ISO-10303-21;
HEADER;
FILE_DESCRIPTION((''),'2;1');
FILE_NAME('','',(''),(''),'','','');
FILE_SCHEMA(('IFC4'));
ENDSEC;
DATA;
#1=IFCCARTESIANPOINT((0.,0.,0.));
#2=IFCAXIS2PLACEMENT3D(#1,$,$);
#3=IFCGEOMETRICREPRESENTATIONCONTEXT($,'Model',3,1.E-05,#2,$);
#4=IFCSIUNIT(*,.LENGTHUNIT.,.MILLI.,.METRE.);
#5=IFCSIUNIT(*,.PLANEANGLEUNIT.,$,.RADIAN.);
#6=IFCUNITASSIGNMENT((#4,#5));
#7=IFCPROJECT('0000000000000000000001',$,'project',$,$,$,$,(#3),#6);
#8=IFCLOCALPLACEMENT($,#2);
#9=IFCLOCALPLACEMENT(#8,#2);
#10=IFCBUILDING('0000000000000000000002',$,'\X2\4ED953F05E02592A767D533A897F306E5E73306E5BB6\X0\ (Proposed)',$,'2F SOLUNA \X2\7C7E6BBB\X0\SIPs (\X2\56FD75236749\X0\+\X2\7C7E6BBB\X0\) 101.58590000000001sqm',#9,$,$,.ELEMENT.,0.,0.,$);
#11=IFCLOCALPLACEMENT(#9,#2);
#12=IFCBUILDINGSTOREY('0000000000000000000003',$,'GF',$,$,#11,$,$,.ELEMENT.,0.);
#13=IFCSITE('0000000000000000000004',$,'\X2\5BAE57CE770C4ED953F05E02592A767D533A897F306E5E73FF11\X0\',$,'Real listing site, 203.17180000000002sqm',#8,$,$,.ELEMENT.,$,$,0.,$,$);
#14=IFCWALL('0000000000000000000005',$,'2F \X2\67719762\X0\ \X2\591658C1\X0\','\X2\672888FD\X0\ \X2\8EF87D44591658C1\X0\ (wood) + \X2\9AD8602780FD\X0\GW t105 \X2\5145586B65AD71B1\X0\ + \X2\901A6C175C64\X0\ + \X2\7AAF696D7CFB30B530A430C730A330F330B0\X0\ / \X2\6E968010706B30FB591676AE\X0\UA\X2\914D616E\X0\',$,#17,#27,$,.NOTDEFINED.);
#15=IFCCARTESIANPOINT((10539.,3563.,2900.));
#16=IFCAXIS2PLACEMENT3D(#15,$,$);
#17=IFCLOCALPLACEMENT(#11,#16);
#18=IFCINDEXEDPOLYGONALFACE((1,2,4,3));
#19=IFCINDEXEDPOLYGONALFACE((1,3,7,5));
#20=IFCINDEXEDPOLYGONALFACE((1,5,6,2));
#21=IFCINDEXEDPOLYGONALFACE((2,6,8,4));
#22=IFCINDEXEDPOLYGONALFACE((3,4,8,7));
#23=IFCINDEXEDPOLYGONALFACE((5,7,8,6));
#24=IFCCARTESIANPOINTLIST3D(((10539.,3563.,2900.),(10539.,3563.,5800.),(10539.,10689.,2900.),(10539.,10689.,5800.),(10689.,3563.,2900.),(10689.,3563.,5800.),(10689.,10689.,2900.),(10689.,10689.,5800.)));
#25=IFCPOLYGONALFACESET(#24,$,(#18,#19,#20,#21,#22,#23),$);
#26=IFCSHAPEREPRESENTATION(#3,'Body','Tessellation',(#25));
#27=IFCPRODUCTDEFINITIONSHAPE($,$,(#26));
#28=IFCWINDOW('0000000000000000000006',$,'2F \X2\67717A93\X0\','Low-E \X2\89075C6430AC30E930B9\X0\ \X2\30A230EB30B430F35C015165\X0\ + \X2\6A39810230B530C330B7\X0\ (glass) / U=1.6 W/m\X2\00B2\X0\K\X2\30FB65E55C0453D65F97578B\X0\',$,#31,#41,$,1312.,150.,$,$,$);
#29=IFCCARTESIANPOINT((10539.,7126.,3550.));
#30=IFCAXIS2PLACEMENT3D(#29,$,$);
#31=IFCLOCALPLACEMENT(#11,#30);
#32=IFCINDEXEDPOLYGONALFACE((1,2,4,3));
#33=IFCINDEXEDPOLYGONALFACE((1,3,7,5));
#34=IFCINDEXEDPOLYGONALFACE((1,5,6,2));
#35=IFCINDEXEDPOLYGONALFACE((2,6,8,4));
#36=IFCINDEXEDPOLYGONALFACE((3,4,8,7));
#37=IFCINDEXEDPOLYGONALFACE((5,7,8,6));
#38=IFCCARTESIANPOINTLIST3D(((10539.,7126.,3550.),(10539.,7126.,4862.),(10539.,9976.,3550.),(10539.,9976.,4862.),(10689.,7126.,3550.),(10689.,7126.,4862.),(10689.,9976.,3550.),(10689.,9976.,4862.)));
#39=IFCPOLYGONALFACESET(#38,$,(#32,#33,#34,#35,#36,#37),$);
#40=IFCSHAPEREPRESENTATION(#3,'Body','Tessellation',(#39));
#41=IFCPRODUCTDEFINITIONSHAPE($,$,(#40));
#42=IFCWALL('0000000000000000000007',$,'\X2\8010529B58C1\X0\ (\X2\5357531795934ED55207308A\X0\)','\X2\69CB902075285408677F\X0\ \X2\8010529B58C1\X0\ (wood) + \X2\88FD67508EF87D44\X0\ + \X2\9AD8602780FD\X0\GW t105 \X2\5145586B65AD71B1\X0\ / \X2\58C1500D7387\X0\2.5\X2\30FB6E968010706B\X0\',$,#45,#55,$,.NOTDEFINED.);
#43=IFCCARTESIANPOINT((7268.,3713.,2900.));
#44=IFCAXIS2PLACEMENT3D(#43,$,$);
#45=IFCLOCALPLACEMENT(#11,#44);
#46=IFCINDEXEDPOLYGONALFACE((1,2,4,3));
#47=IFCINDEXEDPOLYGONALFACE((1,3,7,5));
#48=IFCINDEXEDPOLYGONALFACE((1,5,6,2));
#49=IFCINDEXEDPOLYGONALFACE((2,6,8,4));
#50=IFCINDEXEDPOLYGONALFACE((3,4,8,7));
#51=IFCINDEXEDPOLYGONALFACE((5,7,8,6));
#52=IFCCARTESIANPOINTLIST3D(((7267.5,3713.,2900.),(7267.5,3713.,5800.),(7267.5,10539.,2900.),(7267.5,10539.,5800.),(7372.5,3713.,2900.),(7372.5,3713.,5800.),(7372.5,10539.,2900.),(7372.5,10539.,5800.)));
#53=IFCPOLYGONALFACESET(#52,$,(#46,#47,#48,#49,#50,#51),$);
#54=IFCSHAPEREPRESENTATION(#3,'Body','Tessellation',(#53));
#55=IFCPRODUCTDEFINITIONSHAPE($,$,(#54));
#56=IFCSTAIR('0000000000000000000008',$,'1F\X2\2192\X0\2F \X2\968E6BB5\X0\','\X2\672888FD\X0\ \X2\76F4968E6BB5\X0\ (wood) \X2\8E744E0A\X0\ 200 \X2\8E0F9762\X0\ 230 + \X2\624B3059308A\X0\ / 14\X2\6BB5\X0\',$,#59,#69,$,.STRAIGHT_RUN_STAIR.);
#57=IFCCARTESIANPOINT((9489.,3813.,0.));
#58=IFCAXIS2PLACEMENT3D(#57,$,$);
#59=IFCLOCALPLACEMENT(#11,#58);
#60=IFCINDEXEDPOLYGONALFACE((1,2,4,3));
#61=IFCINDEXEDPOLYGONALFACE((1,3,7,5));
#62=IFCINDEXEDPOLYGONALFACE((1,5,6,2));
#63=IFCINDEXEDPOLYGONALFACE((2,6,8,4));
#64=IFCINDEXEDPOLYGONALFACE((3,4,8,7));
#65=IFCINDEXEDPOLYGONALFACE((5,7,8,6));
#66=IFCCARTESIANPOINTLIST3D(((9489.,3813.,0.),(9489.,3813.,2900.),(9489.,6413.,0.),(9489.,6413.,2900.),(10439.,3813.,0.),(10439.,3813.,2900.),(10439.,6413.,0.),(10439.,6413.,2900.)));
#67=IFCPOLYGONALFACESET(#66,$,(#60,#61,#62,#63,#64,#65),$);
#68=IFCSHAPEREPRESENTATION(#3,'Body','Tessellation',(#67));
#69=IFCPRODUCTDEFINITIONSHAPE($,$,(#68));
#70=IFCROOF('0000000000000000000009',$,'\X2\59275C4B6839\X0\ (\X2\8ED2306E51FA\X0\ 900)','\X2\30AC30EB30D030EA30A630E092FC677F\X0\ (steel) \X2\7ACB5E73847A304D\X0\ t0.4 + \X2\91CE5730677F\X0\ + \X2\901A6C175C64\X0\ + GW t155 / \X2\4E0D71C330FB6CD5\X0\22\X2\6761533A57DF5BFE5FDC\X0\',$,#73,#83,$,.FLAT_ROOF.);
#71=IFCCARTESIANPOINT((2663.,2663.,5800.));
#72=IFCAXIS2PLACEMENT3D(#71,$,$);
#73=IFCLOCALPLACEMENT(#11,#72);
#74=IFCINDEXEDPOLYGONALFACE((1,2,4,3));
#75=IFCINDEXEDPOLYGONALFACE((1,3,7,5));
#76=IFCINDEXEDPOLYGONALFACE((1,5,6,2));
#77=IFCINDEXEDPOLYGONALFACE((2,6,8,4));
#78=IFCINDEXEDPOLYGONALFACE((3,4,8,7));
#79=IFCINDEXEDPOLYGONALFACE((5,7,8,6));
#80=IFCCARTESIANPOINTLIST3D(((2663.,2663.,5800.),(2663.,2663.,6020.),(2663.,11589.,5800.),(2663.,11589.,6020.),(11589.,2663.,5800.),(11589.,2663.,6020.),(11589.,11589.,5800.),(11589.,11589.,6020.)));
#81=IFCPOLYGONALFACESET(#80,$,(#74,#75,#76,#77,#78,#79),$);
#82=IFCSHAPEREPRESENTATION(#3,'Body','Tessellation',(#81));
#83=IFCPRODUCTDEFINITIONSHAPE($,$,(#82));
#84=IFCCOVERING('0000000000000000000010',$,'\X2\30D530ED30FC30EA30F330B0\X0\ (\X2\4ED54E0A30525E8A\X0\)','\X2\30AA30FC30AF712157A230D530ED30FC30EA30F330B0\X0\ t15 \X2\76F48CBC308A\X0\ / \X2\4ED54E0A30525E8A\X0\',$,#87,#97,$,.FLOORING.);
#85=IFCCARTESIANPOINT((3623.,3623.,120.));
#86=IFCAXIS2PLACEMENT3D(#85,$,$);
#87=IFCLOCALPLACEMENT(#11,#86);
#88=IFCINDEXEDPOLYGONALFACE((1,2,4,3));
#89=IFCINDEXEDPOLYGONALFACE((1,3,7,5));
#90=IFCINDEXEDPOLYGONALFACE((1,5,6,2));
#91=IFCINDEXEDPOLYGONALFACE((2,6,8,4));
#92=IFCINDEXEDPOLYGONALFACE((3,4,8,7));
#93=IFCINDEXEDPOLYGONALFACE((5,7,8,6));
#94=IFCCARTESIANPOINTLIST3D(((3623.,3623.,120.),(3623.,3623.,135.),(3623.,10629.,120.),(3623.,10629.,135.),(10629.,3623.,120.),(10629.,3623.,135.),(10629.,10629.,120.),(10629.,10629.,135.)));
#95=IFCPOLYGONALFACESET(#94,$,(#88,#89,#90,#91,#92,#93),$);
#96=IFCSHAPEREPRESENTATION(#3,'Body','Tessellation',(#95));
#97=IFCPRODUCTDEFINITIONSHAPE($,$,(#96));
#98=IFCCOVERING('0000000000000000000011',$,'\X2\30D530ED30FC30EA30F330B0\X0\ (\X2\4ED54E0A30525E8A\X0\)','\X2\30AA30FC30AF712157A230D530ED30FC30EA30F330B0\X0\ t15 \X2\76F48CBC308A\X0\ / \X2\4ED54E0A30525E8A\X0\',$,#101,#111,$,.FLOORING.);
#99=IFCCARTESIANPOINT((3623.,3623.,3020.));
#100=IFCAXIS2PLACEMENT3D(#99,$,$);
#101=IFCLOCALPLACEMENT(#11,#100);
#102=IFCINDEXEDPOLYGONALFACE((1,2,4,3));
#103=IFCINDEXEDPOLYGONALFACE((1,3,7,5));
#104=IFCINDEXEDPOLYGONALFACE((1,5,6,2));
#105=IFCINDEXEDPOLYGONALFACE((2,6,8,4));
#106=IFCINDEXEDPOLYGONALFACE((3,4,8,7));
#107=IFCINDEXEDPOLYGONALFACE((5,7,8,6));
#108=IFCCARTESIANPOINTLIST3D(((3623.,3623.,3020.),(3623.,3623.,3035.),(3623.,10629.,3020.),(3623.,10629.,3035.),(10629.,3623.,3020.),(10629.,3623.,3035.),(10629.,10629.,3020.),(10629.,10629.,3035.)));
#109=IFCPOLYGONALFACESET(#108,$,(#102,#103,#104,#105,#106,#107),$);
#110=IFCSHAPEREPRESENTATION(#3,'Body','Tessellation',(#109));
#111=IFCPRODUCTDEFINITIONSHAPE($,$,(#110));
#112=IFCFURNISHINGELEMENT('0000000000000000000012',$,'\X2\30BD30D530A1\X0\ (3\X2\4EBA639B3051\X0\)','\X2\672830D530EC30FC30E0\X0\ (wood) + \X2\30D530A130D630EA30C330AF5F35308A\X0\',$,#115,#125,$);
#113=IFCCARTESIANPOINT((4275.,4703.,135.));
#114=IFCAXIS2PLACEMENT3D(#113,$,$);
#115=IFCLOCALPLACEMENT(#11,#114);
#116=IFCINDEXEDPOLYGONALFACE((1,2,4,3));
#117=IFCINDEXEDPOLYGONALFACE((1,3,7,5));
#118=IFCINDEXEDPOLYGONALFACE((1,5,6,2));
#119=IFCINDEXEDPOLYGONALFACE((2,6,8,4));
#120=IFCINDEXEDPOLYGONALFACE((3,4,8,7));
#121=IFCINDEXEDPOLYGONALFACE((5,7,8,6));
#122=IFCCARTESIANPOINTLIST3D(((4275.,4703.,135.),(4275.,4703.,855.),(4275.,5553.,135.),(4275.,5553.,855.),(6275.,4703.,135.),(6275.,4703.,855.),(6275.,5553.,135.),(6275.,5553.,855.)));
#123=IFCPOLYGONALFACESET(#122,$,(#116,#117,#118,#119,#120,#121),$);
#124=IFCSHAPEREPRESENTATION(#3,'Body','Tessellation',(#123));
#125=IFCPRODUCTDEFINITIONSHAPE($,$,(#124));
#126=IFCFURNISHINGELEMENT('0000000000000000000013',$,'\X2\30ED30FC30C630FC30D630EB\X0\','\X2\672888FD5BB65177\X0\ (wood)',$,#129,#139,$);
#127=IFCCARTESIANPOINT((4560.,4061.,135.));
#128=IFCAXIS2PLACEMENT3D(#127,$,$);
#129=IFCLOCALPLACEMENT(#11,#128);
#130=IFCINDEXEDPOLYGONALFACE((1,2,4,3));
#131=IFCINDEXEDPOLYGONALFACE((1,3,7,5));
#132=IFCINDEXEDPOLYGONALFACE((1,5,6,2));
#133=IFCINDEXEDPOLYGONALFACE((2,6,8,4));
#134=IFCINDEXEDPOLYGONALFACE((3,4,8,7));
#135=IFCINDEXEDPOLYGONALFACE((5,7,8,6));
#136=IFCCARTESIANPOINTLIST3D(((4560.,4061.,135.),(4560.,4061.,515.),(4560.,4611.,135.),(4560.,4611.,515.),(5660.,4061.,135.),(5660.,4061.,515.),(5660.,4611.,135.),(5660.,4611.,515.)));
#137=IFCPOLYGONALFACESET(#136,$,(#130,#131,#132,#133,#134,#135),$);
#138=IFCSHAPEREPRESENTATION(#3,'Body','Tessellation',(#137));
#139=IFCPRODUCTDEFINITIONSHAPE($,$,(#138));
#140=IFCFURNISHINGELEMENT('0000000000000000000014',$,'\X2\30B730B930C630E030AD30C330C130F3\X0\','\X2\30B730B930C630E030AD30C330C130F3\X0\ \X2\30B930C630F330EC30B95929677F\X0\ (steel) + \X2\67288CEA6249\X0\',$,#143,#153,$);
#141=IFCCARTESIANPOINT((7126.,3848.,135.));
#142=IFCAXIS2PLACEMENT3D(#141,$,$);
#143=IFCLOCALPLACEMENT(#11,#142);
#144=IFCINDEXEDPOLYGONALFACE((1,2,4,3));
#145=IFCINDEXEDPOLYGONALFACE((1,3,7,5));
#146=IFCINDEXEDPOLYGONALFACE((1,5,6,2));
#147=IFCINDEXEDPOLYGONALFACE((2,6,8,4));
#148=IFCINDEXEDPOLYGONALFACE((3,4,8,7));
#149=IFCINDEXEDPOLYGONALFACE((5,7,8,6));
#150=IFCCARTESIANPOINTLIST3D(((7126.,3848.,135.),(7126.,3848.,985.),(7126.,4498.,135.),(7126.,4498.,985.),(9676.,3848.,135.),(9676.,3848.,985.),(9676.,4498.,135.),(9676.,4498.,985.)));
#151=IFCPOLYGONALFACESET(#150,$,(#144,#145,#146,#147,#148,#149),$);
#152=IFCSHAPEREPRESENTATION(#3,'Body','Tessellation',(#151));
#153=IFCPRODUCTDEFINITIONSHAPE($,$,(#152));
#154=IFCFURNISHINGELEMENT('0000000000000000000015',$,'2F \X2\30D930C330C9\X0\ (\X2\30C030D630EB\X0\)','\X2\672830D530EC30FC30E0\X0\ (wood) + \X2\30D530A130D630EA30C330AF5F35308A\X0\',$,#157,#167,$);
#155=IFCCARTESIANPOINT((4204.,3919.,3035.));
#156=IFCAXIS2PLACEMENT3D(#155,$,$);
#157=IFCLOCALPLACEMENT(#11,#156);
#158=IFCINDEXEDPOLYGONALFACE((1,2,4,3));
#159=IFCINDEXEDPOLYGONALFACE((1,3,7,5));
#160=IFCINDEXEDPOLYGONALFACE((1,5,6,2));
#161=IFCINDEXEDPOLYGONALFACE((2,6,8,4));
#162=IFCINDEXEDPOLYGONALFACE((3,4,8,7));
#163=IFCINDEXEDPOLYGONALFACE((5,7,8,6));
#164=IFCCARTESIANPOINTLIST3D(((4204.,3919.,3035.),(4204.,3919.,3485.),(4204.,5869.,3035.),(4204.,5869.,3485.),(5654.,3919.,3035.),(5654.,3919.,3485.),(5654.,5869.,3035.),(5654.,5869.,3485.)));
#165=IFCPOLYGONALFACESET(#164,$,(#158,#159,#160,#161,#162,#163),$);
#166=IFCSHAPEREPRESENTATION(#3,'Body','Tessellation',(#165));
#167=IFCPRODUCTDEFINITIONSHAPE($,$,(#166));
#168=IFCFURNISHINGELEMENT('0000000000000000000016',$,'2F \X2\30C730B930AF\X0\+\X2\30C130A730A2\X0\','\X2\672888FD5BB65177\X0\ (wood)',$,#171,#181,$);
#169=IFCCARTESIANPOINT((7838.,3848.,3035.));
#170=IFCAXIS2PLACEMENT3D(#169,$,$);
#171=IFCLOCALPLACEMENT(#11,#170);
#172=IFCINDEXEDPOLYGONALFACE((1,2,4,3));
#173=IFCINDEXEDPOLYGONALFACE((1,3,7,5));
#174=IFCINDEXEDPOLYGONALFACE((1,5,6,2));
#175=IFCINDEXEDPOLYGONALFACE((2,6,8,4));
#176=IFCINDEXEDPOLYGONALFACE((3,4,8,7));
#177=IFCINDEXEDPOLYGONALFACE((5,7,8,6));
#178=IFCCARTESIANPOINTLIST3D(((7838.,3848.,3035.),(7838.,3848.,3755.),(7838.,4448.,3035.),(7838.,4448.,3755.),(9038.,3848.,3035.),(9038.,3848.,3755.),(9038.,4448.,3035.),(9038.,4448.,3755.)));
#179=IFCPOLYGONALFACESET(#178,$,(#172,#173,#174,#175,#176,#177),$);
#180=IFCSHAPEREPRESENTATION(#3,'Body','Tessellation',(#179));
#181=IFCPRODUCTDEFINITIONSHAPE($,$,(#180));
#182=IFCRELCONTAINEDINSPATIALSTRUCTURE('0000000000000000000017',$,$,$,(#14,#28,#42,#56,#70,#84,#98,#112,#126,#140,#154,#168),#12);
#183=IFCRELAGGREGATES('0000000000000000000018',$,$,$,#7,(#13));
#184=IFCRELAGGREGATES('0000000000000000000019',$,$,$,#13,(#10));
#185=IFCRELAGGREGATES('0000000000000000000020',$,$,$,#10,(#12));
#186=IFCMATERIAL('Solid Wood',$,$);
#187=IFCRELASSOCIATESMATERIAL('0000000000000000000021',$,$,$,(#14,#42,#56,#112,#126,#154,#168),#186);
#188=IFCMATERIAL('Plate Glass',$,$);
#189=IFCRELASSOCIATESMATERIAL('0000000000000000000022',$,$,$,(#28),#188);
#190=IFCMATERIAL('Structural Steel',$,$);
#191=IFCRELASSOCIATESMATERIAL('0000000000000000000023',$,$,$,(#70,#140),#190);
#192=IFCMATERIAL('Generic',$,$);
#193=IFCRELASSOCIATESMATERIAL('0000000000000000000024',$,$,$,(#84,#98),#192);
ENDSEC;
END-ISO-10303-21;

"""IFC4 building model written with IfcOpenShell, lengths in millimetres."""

from ifc_helpers import new_model, si_unit, frame, frame_2d, origin, place, context, project, spatial, rectangle, extrude, material, element, fill, save


model = new_model("IFC4")

# Units and contexts
model_context = context("Model", 3, precision=1e-05, world=origin())
ifc_project = project(units=[si_unit("LENGTHUNIT", "METRE", prefix="MILLI"), si_unit("PLANEANGLEUNIT", "RADIAN")], contexts=[model_context])

# Site, building, storey
site_placement = place(None, origin())
site = spatial("IfcSite", under=ifc_project, at=site_placement, Name="宮城県仙台市太白区西の平１", ObjectType="Real listing site, 203.17180000000002sqm", CompositionType="ELEMENT", RefElevation=0.0)
building_placement = place(site_placement, origin())
building = spatial("IfcBuilding", under=site, at=building_placement, Name="仙台市太白区西の平の家 (Proposed)", ObjectType="2F SOLUNA 籾殻SIPs (国産杉+籾殻) 101.58590000000001sqm", CompositionType="ELEMENT", ElevationOfRefHeight=0.0, ElevationOfTerrain=0.0)
storey_placement = place(building_placement, origin())
storey = spatial("IfcBuildingStorey", under=building, at=storey_placement, Name="GF", CompositionType="ELEMENT", Elevation=0.0)

# Shared definitions
ifc_material_1 = material(Name="Solid Wood")

# Shared definitions
ifc_material_2 = material(Name="Plate Glass")

# Wall, opening, window
wall_1_placement = place(storey_placement, frame((10539.0, 3563.0, 2900.0)))
wall_1 = element("IfcWall", 1, at=wall_1_placement, inside=storey, material=ifc_material_1, Name="2F 東面 外壁", Description="木製 軸組外壁 (wood) + 高性能GW t105 充填断熱 + 通気層 + 窯業系サイディング / 準耐火・外皮UA配慮", PredefinedType="NOTDEFINED", context=model_context, shape_type="SweptSolid", body=[
    extrude(rectangle(XDim=150.0, YDim=7126.0, at=frame_2d((75.0, 3563.0))), frame((10539.0, 3563.0, 2900.0)), (0.0, 0.0, 1.0), 2900.0),
])
opening_1_placement = place(storey_placement, frame((10539.0, 7126.0, 3550.0)))
opening_1 = element("IfcOpeningElement", 2, at=opening_1_placement, cuts=wall_1, PredefinedType="NOTDEFINED", context=model_context, shape_type="SweptSolid", body=[
    extrude(rectangle(XDim=150.0, YDim=2850.0, at=frame_2d((75.0, 1425.0))), frame((10539.0, 7126.0, 3550.0)), (0.0, 0.0, 1.0), 1312.0),
])
window_1_placement = place(storey_placement, frame((10539.0, 7126.0, 3550.0)))
window_1 = element("IfcWindow", 3, at=window_1_placement, inside=storey, material=ifc_material_2, Name="2F 東窓", Description="Low-E 複層ガラス アルゴン封入 + 樹脂サッシ (glass) / U=1.6 W/m²K・日射取得型", OverallHeight=1312.0, OverallWidth=150.0, context=model_context, shape_type="SweptSolid", body=[
    extrude(rectangle(XDim=150.0, YDim=2850.0, at=frame_2d((75.0, 1425.0))), frame((10539.0, 7126.0, 3550.0)), (0.0, 0.0, 1.0), 1312.0),
])
fill(opening_1, window_1)

# Wall
wall_2_placement = place(storey_placement, frame((7268.0, 3713.0, 2900.0)))
element("IfcWall", 4, at=wall_2_placement, inside=storey, material=ifc_material_1, Name="耐力壁 (南北間仕切り)", Description="構造用合板 耐力壁 (wood) + 製材軸組 + 高性能GW t105 充填断熱 / 壁倍率2.5・準耐火", PredefinedType="NOTDEFINED", context=model_context, shape_type="SweptSolid", body=[
    extrude(rectangle(XDim=105.0, YDim=6826.0, at=frame_2d((52.0, 3413.0))), frame((7268.0, 3713.0, 2900.0)), (0.0, 0.0, 1.0), 2900.0),
])

# Stair
stair_placement = place(storey_placement, frame((9489.0, 3813.0, 0.0)))
element("IfcStair", 5, at=stair_placement, inside=storey, material=ifc_material_1, Name="1F→2F 階段", Description="木製 直階段 (wood) 蹴上 200 踏面 230 + 手すり / 14段", PredefinedType="STRAIGHT_RUN_STAIR", context=model_context, shape_type="SweptSolid", body=[
    extrude(rectangle(XDim=950.0, YDim=2600.0, at=frame_2d((475.0, 1300.0))), frame((9489.0, 3813.0, 0.0)), (0.0, 0.0, 1.0), 2900.0),
])

# Roof
ifc_material_3 = material(Name="Structural Steel")
roof_placement = place(storey_placement, frame((2663.0, 2663.0, 5800.0)))
element("IfcRoof", 6, at=roof_placement, inside=storey, material=ifc_material_3, Name="大屋根 (軒の出 900)", Description="ガルバリウム鋼板 (steel) 立平葺き t0.4 + 野地板 + 通気層 + GW t155 / 不燃・法22条区域対応", PredefinedType="FLAT_ROOF", context=model_context, shape_type="SweptSolid", body=[
    extrude(rectangle(XDim=8926.0, YDim=8926.0, at=frame_2d((4463.0, 4463.0))), frame((2663.0, 2663.0, 5800.0)), (0.0, 0.0, 1.0), 220.0),
])

# Coverings
ifc_material_4 = material(Name="Generic")
covering_1_placement = place(storey_placement, frame((3623.0, 3623.0, 120.0)))
element("IfcCovering", 7, at=covering_1_placement, inside=storey, material=ifc_material_4, Name="フローリング (仕上げ床)", Description="オーク無垢フローリング t15 直貼り / 仕上げ床", PredefinedType="FLOORING", context=model_context, shape_type="SweptSolid", body=[
    extrude(rectangle(XDim=7006.0, YDim=7006.0, at=frame_2d((3503.0, 3503.0))), frame((3623.0, 3623.0, 120.0)), (0.0, 0.0, 1.0), 15.0),
])
covering_2_placement = place(storey_placement, frame((3623.0, 3623.0, 3020.0)))
element("IfcCovering", 8, at=covering_2_placement, inside=storey, material=ifc_material_4, Name="フローリング (仕上げ床)", Description="オーク無垢フローリング t15 直貼り / 仕上げ床", PredefinedType="FLOORING", context=model_context, shape_type="SweptSolid", body=[
    extrude(rectangle(XDim=7006.0, YDim=7006.0, at=frame_2d((3503.0, 3503.0))), frame((3623.0, 3623.0, 3020.0)), (0.0, 0.0, 1.0), 15.0),
])

# Furnishing elements
furnishing_1_placement = place(storey_placement, frame((4275.0, 4703.0, 135.0)))
element("IfcFurnishingElement", 9, at=furnishing_1_placement, inside=storey, material=ifc_material_1, Name="ソファ (3人掛け)", Description="木フレーム (wood) + ファブリック張り", context=model_context, shape_type="SweptSolid", body=[
    extrude(rectangle(XDim=2000.0, YDim=850.0, at=frame_2d((1000.0, 425.0))), frame((4275.0, 4703.0, 135.0)), (0.0, 0.0, 1.0), 720.0),
])
furnishing_2_placement = place(storey_placement, frame((4560.0, 4061.0, 135.0)))
element("IfcFurnishingElement", 10, at=furnishing_2_placement, inside=storey, material=ifc_material_1, Name="ローテーブル", Description="木製家具 (wood)", context=model_context, shape_type="SweptSolid", body=[
    extrude(rectangle(XDim=1100.0, YDim=550.0, at=frame_2d((550.0, 275.0))), frame((4560.0, 4061.0, 135.0)), (0.0, 0.0, 1.0), 380.0),
])
furnishing_3_placement = place(storey_placement, frame((7126.0, 3848.0, 135.0)))
element("IfcFurnishingElement", 11, at=furnishing_3_placement, inside=storey, material=ifc_material_3, Name="システムキッチン", Description="システムキッチン ステンレス天板 (steel) + 木質扉", context=model_context, shape_type="SweptSolid", body=[
    extrude(rectangle(XDim=2550.0, YDim=650.0, at=frame_2d((1275.0, 325.0))), frame((7126.0, 3848.0, 135.0)), (0.0, 0.0, 1.0), 850.0),
])
furnishing_4_placement = place(storey_placement, frame((4204.0, 3919.0, 3035.0)))
element("IfcFurnishingElement", 12, at=furnishing_4_placement, inside=storey, material=ifc_material_1, Name="2F ベッド (ダブル)", Description="木フレーム (wood) + ファブリック張り", context=model_context, shape_type="SweptSolid", body=[
    extrude(rectangle(XDim=1450.0, YDim=1950.0, at=frame_2d((725.0, 975.0))), frame((4204.0, 3919.0, 3035.0)), (0.0, 0.0, 1.0), 450.0),
])
furnishing_5_placement = place(storey_placement, frame((7838.0, 3848.0, 3035.0)))
element("IfcFurnishingElement", 13, at=furnishing_5_placement, inside=storey, material=ifc_material_1, Name="2F デスク+チェア", Description="木製家具 (wood)", context=model_context, shape_type="SweptSolid", body=[
    extrude(rectangle(XDim=1200.0, YDim=600.0, at=frame_2d((600.0, 300.0))), frame((7838.0, 3848.0, 3035.0)), (0.0, 0.0, 1.0), 720.0),
])

save(model, "model.ifc")
